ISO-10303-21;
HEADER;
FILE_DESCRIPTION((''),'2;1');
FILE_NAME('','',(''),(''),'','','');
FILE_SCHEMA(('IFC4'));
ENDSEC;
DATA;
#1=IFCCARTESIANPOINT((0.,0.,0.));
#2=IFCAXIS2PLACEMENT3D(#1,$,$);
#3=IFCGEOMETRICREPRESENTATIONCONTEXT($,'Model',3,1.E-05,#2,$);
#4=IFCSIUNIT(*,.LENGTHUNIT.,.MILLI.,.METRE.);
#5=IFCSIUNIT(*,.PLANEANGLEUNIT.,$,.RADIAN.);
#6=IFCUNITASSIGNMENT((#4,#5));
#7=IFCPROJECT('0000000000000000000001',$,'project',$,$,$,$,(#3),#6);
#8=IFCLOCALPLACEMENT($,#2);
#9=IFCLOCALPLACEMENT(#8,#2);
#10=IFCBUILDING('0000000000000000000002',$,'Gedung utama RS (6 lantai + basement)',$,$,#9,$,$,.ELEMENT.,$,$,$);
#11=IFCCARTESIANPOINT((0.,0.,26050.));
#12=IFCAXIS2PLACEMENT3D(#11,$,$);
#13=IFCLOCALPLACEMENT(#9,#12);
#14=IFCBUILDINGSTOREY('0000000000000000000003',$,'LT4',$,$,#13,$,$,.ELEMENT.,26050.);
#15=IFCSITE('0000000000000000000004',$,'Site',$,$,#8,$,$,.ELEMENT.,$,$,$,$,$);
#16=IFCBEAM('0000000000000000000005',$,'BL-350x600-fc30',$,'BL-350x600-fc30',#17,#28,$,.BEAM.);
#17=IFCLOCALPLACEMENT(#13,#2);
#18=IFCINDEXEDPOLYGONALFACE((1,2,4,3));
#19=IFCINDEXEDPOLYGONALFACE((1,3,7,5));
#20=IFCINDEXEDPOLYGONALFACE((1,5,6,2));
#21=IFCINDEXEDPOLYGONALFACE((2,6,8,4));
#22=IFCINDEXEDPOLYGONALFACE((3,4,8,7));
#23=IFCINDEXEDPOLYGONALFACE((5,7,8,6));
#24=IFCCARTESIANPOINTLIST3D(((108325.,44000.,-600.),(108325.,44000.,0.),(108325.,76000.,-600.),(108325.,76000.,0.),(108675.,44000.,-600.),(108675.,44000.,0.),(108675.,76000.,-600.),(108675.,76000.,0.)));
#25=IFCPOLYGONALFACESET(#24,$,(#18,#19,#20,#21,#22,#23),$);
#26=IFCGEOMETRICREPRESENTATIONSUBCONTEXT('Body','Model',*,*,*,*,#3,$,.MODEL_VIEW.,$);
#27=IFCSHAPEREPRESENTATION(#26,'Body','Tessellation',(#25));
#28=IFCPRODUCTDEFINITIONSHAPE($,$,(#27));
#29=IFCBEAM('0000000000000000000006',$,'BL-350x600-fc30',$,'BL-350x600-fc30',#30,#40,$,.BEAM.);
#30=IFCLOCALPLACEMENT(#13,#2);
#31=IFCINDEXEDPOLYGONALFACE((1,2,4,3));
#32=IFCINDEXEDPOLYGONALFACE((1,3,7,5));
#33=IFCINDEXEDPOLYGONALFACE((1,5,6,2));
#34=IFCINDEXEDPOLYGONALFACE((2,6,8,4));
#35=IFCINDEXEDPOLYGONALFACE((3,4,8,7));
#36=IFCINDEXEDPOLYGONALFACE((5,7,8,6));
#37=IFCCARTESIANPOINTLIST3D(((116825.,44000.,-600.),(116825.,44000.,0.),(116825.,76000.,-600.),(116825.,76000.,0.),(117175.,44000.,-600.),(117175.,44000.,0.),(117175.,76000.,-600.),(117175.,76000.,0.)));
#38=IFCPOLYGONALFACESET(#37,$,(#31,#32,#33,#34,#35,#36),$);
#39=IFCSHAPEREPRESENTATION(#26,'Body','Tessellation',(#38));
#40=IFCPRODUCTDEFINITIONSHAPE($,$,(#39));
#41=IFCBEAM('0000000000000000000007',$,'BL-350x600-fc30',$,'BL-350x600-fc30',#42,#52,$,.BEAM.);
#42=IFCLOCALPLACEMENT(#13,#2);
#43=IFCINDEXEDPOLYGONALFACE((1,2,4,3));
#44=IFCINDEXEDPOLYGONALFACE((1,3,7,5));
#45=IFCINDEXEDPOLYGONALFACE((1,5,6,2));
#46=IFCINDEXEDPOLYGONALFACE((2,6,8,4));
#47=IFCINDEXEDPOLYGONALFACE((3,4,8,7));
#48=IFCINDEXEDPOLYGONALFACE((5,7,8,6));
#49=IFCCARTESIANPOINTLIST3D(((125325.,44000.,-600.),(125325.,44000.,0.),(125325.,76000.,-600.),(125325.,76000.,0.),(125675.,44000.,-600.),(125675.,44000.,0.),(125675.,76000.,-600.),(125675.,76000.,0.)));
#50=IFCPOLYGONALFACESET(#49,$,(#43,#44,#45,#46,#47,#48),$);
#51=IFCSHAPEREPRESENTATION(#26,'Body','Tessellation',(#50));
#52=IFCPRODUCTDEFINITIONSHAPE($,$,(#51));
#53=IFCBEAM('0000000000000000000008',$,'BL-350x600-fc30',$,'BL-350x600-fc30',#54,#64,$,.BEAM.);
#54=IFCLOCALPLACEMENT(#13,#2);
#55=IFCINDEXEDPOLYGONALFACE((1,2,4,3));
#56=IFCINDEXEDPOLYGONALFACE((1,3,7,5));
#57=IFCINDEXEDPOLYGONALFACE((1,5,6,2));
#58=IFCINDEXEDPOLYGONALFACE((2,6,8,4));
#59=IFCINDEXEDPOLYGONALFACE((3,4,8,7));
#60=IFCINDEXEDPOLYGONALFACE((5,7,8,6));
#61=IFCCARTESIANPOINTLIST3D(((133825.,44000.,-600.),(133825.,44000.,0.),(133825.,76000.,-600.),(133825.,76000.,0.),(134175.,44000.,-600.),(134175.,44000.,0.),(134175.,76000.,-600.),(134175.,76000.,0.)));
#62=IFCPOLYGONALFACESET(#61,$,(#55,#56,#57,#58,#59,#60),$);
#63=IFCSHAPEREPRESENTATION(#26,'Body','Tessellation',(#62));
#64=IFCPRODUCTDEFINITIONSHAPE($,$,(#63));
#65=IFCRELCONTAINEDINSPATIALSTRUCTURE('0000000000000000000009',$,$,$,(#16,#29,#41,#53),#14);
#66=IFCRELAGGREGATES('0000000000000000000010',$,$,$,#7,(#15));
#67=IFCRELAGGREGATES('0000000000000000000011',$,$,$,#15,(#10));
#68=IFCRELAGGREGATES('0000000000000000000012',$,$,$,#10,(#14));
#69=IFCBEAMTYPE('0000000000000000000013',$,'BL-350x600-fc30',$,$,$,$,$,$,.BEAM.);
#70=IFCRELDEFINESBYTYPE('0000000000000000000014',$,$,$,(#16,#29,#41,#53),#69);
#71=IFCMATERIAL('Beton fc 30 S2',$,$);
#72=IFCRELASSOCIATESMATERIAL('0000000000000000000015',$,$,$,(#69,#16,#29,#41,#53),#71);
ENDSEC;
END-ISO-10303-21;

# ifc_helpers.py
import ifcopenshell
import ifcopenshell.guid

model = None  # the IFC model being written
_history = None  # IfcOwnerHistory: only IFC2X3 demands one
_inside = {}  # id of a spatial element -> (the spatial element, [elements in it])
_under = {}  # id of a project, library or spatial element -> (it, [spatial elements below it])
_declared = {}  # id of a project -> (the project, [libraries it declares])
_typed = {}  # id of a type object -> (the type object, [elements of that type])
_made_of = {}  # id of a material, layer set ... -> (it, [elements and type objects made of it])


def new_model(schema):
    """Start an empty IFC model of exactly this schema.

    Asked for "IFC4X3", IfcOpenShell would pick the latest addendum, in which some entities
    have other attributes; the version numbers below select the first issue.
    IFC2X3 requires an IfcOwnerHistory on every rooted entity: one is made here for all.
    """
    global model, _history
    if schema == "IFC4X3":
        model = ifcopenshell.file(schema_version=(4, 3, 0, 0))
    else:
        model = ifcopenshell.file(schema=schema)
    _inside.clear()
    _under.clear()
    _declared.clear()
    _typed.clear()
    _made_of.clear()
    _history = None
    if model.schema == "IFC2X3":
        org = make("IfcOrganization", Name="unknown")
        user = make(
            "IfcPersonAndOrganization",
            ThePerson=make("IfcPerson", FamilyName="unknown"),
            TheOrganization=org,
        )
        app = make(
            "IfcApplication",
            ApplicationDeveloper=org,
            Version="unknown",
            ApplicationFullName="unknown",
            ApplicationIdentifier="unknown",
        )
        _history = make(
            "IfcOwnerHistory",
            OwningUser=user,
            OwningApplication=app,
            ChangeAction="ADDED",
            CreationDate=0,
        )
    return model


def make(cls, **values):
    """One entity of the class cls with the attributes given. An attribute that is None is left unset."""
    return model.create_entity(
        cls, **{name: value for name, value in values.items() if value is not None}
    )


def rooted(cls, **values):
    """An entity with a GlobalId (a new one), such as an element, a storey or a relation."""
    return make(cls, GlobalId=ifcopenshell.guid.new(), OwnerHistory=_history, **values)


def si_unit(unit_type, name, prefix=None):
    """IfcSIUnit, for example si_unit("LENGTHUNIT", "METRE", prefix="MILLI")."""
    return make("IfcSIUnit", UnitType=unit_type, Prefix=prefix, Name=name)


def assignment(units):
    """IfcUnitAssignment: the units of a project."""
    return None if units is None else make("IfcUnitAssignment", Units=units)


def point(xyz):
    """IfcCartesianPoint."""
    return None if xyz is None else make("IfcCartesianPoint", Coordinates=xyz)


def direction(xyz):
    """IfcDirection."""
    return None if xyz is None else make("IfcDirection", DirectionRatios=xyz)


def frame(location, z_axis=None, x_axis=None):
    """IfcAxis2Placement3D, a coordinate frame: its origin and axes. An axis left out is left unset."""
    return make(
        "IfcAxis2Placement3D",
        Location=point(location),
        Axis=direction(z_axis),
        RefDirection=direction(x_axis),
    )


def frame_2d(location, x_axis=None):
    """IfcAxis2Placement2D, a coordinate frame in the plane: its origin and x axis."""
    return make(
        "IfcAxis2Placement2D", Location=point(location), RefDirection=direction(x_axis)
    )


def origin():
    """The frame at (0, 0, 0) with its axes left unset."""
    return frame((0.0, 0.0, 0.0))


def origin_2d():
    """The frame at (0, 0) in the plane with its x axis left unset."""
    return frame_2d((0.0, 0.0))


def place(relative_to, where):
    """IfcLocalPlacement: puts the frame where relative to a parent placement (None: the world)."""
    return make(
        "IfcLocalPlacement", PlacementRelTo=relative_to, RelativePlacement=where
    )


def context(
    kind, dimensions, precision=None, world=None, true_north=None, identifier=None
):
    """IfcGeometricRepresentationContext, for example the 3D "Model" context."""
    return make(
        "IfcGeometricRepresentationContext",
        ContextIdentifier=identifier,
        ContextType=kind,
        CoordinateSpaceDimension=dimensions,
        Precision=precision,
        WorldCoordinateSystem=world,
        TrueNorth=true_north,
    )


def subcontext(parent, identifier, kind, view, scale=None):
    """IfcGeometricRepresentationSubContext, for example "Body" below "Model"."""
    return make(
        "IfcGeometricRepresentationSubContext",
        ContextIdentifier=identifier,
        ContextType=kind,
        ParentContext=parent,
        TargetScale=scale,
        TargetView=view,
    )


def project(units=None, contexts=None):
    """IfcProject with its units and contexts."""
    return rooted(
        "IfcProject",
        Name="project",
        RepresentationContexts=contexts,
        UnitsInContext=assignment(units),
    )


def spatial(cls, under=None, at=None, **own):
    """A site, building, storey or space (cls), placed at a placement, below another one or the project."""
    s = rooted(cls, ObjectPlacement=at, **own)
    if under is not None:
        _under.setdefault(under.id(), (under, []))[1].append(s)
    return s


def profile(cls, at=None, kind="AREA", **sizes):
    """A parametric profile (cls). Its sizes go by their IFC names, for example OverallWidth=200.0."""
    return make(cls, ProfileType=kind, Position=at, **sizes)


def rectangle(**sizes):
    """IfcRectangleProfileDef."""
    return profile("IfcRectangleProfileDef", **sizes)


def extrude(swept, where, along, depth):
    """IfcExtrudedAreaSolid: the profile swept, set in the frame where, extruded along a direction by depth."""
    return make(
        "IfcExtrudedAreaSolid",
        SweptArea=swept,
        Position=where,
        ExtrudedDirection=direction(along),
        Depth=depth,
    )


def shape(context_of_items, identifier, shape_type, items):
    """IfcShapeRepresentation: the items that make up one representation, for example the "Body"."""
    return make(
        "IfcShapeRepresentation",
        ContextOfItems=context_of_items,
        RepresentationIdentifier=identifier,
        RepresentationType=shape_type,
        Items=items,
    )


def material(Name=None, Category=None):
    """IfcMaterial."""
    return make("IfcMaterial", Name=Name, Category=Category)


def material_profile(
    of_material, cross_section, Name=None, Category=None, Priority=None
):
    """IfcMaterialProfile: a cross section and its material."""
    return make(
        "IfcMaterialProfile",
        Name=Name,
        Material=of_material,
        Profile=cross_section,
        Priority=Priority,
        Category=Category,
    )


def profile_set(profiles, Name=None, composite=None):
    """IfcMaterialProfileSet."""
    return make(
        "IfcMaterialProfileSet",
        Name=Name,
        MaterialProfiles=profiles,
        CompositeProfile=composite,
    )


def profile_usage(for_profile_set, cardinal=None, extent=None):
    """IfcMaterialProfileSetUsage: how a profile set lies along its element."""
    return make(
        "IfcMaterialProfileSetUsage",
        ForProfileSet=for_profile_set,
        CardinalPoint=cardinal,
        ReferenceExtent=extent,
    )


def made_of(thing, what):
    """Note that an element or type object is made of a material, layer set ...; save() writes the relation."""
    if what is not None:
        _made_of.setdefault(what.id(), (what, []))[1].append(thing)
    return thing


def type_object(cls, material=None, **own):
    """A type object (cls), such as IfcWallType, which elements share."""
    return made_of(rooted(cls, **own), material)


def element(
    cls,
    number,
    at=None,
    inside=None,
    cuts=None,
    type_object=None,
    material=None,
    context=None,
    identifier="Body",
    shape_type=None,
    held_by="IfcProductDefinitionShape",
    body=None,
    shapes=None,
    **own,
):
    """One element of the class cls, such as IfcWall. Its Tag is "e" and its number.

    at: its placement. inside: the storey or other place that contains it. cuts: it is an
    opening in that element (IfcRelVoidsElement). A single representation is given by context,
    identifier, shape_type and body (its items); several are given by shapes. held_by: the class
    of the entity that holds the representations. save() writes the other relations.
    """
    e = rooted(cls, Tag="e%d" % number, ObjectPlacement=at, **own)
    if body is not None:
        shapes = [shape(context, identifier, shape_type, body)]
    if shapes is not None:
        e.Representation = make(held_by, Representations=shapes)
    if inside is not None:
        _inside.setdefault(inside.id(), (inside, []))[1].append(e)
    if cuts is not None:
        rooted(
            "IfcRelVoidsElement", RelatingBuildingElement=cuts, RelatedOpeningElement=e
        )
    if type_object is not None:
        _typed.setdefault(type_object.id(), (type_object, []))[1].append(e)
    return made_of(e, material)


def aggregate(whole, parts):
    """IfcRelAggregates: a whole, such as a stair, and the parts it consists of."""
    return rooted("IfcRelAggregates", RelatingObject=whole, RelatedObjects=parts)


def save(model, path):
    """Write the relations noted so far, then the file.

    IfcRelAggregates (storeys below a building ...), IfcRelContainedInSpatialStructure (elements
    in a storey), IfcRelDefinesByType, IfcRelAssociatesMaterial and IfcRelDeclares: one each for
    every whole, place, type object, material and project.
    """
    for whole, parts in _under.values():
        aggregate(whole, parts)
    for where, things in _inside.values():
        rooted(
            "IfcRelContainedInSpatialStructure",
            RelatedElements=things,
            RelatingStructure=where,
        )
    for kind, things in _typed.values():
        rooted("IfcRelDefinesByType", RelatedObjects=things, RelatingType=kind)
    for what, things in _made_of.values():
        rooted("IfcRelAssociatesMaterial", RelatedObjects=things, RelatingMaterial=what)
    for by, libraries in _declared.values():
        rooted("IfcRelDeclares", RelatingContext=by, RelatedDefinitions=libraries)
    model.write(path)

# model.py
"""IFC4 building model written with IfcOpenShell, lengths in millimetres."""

from ifc_helpers import new_model, si_unit, frame, origin, origin_2d, place, context, subcontext, project, spatial, rectangle, extrude, material, material_profile, profile_set, profile_usage, type_object, element, save


model = new_model("IFC4")

# Units and contexts
model_context = context("Model", 3, precision=1e-05, world=origin())
body_context = subcontext(model_context, "Body", "Model", "MODEL_VIEW")
ifc_project = project(units=[si_unit("LENGTHUNIT", "METRE", prefix="MILLI"), si_unit("PLANEANGLEUNIT", "RADIAN")], contexts=[model_context])

# Site, building, storey
site_placement = place(None, origin())
site = spatial("IfcSite", under=ifc_project, at=site_placement, Name="Site", CompositionType="ELEMENT")
building_placement = place(site_placement, origin())
building = spatial("IfcBuilding", under=site, at=building_placement, Name="Gedung utama RS (6 lantai + basement)", CompositionType="ELEMENT")
storey_placement = place(building_placement, frame((0.0, 0.0, 26050.0)))
storey = spatial("IfcBuildingStorey", under=building, at=storey_placement, Name="LT4", CompositionType="ELEMENT", Elevation=26050.0)

# Beams
ifc_material = material(Name="Beton fc 30 S2")
ifc_material_profile_1 = material_profile(ifc_material, rectangle(XDim=350.0, YDim=600.0, at=origin_2d()), Name="BL-350x600-fc30")
ifc_profile_set_1 = profile_set([ifc_material_profile_1], Name="BL-350x600-fc30")
ifc_profile_usage_1 = profile_usage(ifc_profile_set_1, cardinal=8)
beam_type = type_object("IfcBeamType", Name="BL-350x600-fc30", PredefinedType="BEAM", material=ifc_profile_set_1)
for number, where, name in (
    (1, (108500.0, 44000.0, -300.0), "BL-350x600-fc30"),
    (2, (117000.0, 44000.0, -300.0), "BL-350x600-fc30"),
    (3, (125500.0, 44000.0, -300.0), "BL-350x600-fc30"),
    (4, (134000.0, 44000.0, -300.0), "BL-350x600-fc30"),
):
    element("IfcBeam", number, at=place(storey_placement, frame(where)), inside=storey, type_object=beam_type, material=ifc_profile_usage_1, Name=name, ObjectType="BL-350x600-fc30", PredefinedType="BEAM", context=body_context, shape_type="SweptSolid", body=[
        extrude(rectangle(XDim=350.0, YDim=600.0, at=origin_2d()), frame((0.0, 0.0, 0.0), z_axis=(0.0, 1.0, 0.0), x_axis=(-1.0, 0.0, 0.0)), (0.0, 0.0, 1.0), 32000.0),
    ])

save(model, "model.ifc")
